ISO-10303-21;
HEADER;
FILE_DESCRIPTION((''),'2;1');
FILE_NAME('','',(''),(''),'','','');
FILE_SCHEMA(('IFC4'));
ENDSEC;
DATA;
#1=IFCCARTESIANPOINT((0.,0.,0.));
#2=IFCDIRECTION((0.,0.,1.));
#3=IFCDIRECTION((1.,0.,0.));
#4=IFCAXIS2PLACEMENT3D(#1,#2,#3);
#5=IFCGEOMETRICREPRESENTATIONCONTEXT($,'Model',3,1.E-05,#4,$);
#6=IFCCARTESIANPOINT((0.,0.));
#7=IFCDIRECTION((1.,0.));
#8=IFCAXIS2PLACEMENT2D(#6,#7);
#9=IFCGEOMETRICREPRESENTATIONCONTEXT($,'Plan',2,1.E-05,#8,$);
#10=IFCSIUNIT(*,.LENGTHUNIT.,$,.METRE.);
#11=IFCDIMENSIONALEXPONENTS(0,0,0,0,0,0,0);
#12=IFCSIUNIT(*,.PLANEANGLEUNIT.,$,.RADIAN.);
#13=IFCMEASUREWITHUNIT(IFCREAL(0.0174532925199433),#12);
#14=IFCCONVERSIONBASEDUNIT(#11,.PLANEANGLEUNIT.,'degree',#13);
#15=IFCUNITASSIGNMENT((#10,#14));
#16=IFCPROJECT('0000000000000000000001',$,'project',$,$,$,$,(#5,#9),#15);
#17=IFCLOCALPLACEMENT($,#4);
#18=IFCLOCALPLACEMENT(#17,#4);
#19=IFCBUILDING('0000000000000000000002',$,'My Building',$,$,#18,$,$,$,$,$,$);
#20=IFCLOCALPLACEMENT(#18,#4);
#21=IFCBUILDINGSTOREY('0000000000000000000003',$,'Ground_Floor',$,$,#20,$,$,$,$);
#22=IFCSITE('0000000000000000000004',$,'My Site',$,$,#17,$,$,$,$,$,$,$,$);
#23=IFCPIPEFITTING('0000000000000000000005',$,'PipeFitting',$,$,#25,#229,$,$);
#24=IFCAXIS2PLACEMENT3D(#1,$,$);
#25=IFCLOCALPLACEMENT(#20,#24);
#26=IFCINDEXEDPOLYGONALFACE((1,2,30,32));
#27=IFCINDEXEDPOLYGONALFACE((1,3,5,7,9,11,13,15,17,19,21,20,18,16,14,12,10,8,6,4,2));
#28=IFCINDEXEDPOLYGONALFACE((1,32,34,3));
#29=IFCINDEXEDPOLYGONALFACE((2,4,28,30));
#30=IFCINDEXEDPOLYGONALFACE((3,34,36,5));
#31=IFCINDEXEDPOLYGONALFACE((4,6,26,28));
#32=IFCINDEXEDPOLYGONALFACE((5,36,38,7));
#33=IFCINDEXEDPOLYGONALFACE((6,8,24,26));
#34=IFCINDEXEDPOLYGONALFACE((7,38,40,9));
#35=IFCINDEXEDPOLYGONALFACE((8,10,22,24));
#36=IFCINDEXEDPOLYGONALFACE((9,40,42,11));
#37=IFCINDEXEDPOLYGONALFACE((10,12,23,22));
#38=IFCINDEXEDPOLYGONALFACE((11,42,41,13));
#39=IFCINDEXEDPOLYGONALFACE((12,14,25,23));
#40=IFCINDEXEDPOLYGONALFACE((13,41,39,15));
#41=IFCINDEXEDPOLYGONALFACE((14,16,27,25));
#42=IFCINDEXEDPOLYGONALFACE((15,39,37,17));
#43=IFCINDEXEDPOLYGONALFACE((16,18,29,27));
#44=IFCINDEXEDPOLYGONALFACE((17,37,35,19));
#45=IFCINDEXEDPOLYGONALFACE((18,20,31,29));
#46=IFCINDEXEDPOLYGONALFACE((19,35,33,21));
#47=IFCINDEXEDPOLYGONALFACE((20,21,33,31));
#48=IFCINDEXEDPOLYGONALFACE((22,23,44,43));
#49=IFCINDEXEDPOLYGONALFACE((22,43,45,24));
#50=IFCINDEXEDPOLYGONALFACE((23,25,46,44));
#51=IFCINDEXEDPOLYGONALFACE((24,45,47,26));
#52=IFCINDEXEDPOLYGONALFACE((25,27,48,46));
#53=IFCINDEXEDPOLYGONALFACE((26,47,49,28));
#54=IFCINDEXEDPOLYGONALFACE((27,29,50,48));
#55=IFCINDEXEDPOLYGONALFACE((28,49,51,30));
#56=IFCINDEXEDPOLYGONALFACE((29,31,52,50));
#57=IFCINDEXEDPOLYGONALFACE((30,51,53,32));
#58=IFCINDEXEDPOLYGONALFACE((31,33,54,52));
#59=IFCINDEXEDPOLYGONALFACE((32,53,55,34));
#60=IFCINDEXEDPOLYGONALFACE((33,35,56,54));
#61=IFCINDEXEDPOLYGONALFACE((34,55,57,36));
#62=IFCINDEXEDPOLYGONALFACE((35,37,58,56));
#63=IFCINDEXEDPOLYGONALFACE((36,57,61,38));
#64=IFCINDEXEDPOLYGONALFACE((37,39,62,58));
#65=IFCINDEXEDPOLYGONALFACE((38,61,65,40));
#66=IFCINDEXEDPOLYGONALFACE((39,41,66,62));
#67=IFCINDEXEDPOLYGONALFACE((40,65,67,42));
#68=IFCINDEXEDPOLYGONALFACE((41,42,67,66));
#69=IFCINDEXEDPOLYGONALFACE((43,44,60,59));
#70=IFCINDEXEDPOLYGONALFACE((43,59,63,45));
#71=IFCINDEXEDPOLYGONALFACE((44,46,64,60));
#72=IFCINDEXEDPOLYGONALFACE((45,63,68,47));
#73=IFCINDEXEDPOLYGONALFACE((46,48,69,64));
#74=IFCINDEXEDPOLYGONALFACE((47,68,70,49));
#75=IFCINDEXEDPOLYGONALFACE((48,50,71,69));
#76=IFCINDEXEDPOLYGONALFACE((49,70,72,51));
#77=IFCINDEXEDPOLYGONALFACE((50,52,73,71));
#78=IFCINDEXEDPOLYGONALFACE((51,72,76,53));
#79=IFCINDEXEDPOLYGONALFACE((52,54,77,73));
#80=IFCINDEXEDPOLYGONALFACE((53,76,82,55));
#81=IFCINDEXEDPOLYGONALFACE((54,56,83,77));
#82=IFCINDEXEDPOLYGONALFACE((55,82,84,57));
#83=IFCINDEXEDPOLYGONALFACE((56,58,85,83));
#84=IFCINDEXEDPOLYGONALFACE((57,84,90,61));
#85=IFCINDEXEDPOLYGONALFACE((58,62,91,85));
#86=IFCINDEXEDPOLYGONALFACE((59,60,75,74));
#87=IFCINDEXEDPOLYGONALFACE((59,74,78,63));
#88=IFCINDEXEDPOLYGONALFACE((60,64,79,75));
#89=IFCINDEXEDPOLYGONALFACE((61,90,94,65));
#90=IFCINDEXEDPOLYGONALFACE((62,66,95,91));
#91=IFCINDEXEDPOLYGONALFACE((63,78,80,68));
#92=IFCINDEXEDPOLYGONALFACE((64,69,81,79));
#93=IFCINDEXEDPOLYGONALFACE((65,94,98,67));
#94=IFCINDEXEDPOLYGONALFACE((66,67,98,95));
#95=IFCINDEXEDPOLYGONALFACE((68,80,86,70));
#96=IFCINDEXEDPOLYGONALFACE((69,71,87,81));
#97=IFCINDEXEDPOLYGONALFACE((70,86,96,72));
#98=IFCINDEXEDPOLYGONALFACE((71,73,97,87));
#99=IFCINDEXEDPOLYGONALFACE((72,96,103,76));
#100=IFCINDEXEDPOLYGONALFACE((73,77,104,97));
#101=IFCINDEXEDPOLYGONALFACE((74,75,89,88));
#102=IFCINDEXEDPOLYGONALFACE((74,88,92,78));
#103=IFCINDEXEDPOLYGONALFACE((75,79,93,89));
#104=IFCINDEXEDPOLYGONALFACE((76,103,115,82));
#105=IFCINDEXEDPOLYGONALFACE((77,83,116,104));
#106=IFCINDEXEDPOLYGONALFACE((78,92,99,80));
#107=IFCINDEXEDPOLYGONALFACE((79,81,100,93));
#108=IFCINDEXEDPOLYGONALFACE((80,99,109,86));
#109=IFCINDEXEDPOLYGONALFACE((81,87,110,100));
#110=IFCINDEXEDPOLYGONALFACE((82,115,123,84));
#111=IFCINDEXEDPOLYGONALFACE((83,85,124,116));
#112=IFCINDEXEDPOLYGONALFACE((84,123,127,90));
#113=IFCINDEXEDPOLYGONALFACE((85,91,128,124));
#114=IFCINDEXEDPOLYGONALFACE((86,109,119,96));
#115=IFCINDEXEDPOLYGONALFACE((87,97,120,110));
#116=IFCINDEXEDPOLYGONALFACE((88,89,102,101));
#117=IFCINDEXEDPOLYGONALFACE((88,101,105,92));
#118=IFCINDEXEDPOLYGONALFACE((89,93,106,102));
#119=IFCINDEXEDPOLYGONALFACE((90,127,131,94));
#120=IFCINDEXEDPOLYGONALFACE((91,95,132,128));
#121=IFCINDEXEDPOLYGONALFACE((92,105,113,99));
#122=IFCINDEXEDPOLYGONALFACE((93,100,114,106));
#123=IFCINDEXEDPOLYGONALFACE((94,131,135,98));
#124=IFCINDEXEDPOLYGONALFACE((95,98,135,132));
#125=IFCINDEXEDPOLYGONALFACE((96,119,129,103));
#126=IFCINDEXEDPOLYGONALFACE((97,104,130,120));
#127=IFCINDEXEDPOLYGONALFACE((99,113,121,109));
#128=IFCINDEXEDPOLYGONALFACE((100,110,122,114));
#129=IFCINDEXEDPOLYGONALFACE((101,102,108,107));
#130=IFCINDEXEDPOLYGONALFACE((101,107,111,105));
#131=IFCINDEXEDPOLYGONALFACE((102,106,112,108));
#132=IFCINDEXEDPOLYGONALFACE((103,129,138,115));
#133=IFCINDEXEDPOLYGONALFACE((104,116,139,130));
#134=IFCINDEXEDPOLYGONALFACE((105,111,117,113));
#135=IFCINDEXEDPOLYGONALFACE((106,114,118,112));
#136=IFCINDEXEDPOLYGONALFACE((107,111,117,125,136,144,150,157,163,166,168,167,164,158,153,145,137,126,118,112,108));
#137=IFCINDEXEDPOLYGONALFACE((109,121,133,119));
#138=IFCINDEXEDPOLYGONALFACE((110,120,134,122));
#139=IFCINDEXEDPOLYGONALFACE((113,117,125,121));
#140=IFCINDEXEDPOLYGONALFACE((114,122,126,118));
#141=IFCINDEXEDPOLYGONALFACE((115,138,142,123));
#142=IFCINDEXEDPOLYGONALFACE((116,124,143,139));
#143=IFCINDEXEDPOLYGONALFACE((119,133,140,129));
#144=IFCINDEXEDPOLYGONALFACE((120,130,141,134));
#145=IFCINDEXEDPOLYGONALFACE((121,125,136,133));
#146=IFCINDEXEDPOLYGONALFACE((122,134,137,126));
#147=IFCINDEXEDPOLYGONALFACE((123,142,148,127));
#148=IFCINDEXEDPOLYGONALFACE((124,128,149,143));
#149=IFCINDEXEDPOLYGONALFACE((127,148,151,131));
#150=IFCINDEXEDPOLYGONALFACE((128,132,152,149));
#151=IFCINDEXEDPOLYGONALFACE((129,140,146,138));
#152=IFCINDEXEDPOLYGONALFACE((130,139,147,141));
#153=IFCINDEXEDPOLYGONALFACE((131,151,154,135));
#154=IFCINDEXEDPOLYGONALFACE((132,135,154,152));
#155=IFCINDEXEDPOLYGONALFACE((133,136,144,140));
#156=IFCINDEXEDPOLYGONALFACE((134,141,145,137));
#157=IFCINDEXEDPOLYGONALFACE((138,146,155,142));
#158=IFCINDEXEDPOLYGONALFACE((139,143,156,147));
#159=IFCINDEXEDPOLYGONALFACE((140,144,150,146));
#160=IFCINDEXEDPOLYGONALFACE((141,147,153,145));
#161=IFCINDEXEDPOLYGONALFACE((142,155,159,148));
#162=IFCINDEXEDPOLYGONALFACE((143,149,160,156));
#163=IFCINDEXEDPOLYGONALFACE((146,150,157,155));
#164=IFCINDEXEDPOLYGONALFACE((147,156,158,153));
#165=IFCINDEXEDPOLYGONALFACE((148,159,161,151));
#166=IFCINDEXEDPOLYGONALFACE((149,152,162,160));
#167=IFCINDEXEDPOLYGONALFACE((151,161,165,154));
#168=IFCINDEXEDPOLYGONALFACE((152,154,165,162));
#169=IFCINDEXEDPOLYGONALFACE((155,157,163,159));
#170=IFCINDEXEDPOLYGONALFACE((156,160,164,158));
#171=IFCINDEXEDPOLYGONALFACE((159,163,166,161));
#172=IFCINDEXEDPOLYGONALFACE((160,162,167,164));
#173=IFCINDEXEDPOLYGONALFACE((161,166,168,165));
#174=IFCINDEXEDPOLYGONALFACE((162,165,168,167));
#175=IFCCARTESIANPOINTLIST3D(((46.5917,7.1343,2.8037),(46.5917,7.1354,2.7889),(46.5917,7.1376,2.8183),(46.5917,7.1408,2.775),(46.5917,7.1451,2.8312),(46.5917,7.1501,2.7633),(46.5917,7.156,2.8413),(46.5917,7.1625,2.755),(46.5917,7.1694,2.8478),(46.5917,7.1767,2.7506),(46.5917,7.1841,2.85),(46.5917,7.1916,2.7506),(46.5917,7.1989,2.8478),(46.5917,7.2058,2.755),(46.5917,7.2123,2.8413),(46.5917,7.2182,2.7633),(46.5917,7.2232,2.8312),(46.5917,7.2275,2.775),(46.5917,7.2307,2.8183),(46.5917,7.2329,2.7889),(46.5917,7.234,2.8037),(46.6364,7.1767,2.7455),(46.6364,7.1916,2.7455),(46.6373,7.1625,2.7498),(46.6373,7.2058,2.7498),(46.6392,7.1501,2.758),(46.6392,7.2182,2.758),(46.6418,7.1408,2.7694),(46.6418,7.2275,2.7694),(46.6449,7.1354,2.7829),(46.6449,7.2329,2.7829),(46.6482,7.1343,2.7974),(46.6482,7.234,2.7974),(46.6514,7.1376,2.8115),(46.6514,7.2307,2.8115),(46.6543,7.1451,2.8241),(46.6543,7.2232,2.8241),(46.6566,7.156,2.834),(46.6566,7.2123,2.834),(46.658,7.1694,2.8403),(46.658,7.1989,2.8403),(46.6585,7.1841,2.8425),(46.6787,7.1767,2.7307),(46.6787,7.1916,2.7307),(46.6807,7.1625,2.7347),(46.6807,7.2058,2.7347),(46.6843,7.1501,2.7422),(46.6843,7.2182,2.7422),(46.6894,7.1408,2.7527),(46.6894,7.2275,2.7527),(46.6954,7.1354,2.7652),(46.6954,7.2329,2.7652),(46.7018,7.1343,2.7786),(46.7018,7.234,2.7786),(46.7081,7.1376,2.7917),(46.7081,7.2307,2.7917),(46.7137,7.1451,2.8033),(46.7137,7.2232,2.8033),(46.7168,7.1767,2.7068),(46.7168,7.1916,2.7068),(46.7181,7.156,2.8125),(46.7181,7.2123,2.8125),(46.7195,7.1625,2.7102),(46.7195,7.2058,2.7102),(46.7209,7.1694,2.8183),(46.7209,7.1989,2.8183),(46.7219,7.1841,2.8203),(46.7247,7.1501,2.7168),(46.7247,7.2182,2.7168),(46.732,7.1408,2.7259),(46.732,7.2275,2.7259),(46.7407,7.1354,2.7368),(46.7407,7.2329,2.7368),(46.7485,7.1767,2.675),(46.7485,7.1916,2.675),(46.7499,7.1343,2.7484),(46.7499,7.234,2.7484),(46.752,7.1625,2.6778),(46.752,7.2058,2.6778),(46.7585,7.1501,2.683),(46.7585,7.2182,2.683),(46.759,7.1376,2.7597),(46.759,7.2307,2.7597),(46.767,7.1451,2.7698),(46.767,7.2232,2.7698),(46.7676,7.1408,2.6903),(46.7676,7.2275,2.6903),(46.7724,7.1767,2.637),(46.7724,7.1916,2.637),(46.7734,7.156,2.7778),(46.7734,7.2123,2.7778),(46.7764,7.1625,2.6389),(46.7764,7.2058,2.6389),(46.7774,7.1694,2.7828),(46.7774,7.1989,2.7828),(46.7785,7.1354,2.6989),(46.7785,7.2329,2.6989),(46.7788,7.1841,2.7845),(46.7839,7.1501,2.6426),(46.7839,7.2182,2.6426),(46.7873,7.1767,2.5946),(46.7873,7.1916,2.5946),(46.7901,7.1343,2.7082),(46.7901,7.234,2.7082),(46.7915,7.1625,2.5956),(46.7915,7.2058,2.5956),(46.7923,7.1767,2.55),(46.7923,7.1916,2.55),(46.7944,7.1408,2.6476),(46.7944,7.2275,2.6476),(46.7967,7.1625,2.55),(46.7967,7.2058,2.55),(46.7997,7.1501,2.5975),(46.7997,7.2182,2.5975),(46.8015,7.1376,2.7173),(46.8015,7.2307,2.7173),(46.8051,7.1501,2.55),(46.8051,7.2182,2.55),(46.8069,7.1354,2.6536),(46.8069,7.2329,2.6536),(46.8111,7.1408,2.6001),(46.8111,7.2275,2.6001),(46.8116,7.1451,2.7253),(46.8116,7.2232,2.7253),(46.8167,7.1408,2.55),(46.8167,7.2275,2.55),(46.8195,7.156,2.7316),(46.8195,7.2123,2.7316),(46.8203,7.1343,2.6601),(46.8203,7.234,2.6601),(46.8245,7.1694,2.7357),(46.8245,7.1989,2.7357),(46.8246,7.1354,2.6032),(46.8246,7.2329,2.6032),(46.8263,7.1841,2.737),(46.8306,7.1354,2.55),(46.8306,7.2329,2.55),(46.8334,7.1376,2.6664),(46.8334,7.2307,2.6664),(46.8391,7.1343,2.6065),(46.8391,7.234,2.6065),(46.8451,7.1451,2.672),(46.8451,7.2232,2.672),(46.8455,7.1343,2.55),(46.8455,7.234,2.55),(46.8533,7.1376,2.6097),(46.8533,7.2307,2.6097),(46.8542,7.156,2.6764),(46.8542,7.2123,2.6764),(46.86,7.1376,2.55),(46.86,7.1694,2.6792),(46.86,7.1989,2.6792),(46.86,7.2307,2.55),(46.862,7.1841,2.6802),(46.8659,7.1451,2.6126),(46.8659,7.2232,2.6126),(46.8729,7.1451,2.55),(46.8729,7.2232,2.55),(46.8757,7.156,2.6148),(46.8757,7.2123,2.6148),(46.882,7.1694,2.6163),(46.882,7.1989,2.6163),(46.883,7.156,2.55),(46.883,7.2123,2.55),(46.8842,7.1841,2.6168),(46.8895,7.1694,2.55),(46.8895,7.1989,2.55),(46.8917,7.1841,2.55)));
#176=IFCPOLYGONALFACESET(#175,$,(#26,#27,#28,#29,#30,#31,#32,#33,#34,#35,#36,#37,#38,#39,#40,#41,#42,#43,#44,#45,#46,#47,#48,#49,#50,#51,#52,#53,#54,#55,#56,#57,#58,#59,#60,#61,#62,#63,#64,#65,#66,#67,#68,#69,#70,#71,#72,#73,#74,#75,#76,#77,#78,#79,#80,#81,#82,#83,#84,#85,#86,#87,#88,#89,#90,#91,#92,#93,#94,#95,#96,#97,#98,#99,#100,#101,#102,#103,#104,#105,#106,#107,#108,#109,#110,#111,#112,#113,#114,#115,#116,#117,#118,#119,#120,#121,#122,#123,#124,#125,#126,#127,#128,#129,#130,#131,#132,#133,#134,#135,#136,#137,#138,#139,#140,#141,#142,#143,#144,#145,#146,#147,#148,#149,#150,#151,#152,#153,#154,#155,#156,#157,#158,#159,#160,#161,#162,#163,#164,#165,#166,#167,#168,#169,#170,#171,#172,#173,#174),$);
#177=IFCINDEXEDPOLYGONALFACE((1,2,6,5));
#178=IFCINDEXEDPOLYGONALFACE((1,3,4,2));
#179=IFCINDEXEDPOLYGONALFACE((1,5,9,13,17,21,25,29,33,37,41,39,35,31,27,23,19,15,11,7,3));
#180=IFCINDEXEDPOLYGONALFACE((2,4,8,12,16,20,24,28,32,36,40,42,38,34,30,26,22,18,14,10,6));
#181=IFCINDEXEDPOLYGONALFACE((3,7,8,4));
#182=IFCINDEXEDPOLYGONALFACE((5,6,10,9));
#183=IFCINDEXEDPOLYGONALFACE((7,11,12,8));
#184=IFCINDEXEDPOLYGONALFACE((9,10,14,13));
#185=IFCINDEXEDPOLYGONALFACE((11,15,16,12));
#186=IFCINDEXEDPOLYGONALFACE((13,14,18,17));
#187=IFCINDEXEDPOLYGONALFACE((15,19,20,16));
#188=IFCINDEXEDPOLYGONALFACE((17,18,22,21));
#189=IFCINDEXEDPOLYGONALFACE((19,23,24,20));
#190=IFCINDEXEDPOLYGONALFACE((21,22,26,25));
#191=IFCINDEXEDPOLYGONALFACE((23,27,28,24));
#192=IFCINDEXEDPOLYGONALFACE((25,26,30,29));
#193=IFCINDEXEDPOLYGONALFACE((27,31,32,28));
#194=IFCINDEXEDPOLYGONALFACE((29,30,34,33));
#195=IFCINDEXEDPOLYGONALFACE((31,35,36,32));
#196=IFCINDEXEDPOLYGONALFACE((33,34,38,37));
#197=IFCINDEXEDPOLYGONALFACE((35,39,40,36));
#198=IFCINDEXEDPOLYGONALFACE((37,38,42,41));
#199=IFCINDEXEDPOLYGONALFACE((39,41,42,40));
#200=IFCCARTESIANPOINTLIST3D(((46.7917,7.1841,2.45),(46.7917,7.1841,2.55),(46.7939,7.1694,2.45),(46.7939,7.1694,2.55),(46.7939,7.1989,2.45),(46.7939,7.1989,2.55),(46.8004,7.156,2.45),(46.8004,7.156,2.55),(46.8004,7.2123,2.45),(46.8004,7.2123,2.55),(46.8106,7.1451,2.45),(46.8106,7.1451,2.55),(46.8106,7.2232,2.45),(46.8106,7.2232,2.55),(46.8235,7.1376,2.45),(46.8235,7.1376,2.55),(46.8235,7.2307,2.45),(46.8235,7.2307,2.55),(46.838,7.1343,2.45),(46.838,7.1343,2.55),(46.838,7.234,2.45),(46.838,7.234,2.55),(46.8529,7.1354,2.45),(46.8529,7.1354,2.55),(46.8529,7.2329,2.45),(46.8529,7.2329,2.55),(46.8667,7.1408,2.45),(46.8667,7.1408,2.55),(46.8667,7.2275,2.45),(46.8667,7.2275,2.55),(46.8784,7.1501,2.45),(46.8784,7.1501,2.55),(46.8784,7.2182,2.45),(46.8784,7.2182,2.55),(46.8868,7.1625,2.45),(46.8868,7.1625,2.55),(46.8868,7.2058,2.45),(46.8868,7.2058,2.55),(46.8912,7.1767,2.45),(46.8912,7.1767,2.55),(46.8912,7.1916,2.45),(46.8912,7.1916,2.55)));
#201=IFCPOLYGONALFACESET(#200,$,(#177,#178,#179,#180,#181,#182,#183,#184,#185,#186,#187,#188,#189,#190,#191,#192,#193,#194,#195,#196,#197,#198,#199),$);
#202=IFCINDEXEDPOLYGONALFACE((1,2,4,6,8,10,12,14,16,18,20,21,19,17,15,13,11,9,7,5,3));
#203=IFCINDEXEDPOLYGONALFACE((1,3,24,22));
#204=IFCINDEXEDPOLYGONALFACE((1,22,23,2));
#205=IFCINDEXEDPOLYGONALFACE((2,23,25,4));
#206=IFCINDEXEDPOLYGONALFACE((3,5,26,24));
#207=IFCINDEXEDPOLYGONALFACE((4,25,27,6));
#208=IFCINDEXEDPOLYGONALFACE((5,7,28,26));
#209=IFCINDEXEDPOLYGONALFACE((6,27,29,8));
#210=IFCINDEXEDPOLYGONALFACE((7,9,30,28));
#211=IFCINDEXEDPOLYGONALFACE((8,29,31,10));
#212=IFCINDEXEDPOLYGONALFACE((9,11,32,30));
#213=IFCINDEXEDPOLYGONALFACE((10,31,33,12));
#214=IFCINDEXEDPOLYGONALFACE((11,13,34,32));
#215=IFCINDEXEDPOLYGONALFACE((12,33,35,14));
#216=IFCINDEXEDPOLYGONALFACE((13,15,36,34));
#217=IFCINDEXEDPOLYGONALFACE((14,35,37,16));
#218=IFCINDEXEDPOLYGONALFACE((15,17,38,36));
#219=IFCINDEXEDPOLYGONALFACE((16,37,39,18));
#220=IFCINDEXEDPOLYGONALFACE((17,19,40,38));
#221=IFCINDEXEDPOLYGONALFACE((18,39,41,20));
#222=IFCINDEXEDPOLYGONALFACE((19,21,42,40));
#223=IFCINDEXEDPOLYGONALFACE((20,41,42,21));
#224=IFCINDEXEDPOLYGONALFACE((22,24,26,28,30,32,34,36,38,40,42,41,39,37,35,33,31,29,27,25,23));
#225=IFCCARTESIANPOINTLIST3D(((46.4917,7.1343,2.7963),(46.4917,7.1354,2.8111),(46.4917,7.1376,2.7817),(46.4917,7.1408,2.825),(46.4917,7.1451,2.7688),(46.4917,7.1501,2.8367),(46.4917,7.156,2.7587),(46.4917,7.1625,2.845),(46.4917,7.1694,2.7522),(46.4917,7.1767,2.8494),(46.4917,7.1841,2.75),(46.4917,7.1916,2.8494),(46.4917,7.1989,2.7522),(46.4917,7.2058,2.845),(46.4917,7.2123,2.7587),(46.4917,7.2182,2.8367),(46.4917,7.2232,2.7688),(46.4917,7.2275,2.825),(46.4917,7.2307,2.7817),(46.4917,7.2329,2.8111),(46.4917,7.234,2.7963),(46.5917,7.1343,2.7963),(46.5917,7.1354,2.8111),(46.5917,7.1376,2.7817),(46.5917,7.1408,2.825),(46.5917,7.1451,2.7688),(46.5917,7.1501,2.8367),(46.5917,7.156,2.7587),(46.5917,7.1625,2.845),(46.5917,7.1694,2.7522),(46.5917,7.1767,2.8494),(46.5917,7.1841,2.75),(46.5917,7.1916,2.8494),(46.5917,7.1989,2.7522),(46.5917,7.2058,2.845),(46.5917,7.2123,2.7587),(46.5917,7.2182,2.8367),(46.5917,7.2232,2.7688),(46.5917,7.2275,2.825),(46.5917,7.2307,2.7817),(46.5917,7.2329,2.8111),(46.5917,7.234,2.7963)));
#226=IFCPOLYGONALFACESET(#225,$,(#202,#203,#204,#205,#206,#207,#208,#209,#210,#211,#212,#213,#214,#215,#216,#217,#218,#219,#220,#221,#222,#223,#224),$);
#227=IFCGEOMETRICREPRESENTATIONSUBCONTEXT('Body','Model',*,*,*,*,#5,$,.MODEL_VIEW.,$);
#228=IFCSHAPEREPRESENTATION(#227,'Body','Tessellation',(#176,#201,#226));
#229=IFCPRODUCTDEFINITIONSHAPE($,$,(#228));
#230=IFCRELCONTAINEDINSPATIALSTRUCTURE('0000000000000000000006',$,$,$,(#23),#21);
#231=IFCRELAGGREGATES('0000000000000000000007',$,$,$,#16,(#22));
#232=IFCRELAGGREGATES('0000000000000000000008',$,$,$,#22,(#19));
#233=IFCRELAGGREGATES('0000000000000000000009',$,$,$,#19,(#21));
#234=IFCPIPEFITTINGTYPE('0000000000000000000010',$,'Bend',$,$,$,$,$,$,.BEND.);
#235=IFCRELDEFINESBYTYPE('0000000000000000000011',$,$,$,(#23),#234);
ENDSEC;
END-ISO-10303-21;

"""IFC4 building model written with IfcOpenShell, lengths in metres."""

from ifc_helpers import new_model, entity, si_unit, converted_unit, frame, origin_with_axes, origin_2d_with_axis, place, context, subcontext, project, spatial, circle, extrude, source, transform, mapped, type_object, type_shapes, element, save


model = new_model("IFC4")

# Units and contexts
model_context = context("Model", 3, precision=1e-05, world=origin_with_axes())
plan_context = context("Plan", 2, precision=1e-05, world=origin_2d_with_axis())
body_context = subcontext(model_context, "Body", "Model", "MODEL_VIEW")
ifc_project = project(units=[si_unit("LENGTHUNIT", "METRE"), converted_unit("PLANEANGLEUNIT", "degree", entity("IfcReal", 0.0174532925199433), si_unit("PLANEANGLEUNIT", "RADIAN"), dimensions=[0, 0, 0, 0, 0, 0, 0])], contexts=[model_context, plan_context])

# Site, building, storey
site_placement = place(None, origin_with_axes())
site = spatial("IfcSite", under=ifc_project, at=site_placement, Name="My Site")
building_placement = place(site_placement, origin_with_axes())
building = spatial("IfcBuilding", under=site, at=building_placement, Name="My Building")
storey_placement = place(building_placement, origin_with_axes())
storey = spatial("IfcBuildingStorey", under=building, at=storey_placement, Name="Ground_Floor")

# Pipe fitting
pipe_fitting_type = type_object("IfcPipeFittingType", Name="Bend", PredefinedType="BEND")
shared_shape_1 = source(origin_with_axes(), body_context, "Body", "SolidModel", [
    entity("IfcSweptDiskSolid", entity("IfcIndexedPolyCurve", entity("IfcCartesianPointList3D", [[0.0, 0.0, -0.1], [0.0732, 0.0, -0.2768], [0.25, 0.0, -0.35]]), [entity("IfcArcIndex", [1, 2, 3])]), 0.05),
    extrude(circle(Radius=0.05), origin_with_axes(), (0.0, 0.0, -1.0), 0.1),
    extrude(circle(Radius=0.05), frame((0.25, 0.0, -0.35), z_axis=(1.0, 0.0, 0.0), x_axis=(0.0, 0.0, 1.0)), (0.0, 0.0, 1.0), 0.1),
])
type_shapes(pipe_fitting_type, [shared_shape_1])
for number, where, z_axis, x_axis, name in (
    (1, (46.8417, 7.1841, 2.45), (0.0, 0.0, -1.0), (-1.0, 0.0, 0.0), "PipeFitting"),
):
    element("IfcPipeFitting", number, at=place(storey_placement, frame(where, z_axis=z_axis, x_axis=x_axis)), inside=storey, type_object=pipe_fitting_type, Name=name, context=body_context, shape_type="MappedRepresentation", body=[
        mapped(shared_shape_1, transform((0.0, 0.0, 0.0), x_axis=(1.0, 0.0, 0.0), y_axis=(0.0, 1.0, 0.0), z_axis=(0.0, 0.0, 1.0), scale=1.0)),
    ])

save(model, "model.ifc")
